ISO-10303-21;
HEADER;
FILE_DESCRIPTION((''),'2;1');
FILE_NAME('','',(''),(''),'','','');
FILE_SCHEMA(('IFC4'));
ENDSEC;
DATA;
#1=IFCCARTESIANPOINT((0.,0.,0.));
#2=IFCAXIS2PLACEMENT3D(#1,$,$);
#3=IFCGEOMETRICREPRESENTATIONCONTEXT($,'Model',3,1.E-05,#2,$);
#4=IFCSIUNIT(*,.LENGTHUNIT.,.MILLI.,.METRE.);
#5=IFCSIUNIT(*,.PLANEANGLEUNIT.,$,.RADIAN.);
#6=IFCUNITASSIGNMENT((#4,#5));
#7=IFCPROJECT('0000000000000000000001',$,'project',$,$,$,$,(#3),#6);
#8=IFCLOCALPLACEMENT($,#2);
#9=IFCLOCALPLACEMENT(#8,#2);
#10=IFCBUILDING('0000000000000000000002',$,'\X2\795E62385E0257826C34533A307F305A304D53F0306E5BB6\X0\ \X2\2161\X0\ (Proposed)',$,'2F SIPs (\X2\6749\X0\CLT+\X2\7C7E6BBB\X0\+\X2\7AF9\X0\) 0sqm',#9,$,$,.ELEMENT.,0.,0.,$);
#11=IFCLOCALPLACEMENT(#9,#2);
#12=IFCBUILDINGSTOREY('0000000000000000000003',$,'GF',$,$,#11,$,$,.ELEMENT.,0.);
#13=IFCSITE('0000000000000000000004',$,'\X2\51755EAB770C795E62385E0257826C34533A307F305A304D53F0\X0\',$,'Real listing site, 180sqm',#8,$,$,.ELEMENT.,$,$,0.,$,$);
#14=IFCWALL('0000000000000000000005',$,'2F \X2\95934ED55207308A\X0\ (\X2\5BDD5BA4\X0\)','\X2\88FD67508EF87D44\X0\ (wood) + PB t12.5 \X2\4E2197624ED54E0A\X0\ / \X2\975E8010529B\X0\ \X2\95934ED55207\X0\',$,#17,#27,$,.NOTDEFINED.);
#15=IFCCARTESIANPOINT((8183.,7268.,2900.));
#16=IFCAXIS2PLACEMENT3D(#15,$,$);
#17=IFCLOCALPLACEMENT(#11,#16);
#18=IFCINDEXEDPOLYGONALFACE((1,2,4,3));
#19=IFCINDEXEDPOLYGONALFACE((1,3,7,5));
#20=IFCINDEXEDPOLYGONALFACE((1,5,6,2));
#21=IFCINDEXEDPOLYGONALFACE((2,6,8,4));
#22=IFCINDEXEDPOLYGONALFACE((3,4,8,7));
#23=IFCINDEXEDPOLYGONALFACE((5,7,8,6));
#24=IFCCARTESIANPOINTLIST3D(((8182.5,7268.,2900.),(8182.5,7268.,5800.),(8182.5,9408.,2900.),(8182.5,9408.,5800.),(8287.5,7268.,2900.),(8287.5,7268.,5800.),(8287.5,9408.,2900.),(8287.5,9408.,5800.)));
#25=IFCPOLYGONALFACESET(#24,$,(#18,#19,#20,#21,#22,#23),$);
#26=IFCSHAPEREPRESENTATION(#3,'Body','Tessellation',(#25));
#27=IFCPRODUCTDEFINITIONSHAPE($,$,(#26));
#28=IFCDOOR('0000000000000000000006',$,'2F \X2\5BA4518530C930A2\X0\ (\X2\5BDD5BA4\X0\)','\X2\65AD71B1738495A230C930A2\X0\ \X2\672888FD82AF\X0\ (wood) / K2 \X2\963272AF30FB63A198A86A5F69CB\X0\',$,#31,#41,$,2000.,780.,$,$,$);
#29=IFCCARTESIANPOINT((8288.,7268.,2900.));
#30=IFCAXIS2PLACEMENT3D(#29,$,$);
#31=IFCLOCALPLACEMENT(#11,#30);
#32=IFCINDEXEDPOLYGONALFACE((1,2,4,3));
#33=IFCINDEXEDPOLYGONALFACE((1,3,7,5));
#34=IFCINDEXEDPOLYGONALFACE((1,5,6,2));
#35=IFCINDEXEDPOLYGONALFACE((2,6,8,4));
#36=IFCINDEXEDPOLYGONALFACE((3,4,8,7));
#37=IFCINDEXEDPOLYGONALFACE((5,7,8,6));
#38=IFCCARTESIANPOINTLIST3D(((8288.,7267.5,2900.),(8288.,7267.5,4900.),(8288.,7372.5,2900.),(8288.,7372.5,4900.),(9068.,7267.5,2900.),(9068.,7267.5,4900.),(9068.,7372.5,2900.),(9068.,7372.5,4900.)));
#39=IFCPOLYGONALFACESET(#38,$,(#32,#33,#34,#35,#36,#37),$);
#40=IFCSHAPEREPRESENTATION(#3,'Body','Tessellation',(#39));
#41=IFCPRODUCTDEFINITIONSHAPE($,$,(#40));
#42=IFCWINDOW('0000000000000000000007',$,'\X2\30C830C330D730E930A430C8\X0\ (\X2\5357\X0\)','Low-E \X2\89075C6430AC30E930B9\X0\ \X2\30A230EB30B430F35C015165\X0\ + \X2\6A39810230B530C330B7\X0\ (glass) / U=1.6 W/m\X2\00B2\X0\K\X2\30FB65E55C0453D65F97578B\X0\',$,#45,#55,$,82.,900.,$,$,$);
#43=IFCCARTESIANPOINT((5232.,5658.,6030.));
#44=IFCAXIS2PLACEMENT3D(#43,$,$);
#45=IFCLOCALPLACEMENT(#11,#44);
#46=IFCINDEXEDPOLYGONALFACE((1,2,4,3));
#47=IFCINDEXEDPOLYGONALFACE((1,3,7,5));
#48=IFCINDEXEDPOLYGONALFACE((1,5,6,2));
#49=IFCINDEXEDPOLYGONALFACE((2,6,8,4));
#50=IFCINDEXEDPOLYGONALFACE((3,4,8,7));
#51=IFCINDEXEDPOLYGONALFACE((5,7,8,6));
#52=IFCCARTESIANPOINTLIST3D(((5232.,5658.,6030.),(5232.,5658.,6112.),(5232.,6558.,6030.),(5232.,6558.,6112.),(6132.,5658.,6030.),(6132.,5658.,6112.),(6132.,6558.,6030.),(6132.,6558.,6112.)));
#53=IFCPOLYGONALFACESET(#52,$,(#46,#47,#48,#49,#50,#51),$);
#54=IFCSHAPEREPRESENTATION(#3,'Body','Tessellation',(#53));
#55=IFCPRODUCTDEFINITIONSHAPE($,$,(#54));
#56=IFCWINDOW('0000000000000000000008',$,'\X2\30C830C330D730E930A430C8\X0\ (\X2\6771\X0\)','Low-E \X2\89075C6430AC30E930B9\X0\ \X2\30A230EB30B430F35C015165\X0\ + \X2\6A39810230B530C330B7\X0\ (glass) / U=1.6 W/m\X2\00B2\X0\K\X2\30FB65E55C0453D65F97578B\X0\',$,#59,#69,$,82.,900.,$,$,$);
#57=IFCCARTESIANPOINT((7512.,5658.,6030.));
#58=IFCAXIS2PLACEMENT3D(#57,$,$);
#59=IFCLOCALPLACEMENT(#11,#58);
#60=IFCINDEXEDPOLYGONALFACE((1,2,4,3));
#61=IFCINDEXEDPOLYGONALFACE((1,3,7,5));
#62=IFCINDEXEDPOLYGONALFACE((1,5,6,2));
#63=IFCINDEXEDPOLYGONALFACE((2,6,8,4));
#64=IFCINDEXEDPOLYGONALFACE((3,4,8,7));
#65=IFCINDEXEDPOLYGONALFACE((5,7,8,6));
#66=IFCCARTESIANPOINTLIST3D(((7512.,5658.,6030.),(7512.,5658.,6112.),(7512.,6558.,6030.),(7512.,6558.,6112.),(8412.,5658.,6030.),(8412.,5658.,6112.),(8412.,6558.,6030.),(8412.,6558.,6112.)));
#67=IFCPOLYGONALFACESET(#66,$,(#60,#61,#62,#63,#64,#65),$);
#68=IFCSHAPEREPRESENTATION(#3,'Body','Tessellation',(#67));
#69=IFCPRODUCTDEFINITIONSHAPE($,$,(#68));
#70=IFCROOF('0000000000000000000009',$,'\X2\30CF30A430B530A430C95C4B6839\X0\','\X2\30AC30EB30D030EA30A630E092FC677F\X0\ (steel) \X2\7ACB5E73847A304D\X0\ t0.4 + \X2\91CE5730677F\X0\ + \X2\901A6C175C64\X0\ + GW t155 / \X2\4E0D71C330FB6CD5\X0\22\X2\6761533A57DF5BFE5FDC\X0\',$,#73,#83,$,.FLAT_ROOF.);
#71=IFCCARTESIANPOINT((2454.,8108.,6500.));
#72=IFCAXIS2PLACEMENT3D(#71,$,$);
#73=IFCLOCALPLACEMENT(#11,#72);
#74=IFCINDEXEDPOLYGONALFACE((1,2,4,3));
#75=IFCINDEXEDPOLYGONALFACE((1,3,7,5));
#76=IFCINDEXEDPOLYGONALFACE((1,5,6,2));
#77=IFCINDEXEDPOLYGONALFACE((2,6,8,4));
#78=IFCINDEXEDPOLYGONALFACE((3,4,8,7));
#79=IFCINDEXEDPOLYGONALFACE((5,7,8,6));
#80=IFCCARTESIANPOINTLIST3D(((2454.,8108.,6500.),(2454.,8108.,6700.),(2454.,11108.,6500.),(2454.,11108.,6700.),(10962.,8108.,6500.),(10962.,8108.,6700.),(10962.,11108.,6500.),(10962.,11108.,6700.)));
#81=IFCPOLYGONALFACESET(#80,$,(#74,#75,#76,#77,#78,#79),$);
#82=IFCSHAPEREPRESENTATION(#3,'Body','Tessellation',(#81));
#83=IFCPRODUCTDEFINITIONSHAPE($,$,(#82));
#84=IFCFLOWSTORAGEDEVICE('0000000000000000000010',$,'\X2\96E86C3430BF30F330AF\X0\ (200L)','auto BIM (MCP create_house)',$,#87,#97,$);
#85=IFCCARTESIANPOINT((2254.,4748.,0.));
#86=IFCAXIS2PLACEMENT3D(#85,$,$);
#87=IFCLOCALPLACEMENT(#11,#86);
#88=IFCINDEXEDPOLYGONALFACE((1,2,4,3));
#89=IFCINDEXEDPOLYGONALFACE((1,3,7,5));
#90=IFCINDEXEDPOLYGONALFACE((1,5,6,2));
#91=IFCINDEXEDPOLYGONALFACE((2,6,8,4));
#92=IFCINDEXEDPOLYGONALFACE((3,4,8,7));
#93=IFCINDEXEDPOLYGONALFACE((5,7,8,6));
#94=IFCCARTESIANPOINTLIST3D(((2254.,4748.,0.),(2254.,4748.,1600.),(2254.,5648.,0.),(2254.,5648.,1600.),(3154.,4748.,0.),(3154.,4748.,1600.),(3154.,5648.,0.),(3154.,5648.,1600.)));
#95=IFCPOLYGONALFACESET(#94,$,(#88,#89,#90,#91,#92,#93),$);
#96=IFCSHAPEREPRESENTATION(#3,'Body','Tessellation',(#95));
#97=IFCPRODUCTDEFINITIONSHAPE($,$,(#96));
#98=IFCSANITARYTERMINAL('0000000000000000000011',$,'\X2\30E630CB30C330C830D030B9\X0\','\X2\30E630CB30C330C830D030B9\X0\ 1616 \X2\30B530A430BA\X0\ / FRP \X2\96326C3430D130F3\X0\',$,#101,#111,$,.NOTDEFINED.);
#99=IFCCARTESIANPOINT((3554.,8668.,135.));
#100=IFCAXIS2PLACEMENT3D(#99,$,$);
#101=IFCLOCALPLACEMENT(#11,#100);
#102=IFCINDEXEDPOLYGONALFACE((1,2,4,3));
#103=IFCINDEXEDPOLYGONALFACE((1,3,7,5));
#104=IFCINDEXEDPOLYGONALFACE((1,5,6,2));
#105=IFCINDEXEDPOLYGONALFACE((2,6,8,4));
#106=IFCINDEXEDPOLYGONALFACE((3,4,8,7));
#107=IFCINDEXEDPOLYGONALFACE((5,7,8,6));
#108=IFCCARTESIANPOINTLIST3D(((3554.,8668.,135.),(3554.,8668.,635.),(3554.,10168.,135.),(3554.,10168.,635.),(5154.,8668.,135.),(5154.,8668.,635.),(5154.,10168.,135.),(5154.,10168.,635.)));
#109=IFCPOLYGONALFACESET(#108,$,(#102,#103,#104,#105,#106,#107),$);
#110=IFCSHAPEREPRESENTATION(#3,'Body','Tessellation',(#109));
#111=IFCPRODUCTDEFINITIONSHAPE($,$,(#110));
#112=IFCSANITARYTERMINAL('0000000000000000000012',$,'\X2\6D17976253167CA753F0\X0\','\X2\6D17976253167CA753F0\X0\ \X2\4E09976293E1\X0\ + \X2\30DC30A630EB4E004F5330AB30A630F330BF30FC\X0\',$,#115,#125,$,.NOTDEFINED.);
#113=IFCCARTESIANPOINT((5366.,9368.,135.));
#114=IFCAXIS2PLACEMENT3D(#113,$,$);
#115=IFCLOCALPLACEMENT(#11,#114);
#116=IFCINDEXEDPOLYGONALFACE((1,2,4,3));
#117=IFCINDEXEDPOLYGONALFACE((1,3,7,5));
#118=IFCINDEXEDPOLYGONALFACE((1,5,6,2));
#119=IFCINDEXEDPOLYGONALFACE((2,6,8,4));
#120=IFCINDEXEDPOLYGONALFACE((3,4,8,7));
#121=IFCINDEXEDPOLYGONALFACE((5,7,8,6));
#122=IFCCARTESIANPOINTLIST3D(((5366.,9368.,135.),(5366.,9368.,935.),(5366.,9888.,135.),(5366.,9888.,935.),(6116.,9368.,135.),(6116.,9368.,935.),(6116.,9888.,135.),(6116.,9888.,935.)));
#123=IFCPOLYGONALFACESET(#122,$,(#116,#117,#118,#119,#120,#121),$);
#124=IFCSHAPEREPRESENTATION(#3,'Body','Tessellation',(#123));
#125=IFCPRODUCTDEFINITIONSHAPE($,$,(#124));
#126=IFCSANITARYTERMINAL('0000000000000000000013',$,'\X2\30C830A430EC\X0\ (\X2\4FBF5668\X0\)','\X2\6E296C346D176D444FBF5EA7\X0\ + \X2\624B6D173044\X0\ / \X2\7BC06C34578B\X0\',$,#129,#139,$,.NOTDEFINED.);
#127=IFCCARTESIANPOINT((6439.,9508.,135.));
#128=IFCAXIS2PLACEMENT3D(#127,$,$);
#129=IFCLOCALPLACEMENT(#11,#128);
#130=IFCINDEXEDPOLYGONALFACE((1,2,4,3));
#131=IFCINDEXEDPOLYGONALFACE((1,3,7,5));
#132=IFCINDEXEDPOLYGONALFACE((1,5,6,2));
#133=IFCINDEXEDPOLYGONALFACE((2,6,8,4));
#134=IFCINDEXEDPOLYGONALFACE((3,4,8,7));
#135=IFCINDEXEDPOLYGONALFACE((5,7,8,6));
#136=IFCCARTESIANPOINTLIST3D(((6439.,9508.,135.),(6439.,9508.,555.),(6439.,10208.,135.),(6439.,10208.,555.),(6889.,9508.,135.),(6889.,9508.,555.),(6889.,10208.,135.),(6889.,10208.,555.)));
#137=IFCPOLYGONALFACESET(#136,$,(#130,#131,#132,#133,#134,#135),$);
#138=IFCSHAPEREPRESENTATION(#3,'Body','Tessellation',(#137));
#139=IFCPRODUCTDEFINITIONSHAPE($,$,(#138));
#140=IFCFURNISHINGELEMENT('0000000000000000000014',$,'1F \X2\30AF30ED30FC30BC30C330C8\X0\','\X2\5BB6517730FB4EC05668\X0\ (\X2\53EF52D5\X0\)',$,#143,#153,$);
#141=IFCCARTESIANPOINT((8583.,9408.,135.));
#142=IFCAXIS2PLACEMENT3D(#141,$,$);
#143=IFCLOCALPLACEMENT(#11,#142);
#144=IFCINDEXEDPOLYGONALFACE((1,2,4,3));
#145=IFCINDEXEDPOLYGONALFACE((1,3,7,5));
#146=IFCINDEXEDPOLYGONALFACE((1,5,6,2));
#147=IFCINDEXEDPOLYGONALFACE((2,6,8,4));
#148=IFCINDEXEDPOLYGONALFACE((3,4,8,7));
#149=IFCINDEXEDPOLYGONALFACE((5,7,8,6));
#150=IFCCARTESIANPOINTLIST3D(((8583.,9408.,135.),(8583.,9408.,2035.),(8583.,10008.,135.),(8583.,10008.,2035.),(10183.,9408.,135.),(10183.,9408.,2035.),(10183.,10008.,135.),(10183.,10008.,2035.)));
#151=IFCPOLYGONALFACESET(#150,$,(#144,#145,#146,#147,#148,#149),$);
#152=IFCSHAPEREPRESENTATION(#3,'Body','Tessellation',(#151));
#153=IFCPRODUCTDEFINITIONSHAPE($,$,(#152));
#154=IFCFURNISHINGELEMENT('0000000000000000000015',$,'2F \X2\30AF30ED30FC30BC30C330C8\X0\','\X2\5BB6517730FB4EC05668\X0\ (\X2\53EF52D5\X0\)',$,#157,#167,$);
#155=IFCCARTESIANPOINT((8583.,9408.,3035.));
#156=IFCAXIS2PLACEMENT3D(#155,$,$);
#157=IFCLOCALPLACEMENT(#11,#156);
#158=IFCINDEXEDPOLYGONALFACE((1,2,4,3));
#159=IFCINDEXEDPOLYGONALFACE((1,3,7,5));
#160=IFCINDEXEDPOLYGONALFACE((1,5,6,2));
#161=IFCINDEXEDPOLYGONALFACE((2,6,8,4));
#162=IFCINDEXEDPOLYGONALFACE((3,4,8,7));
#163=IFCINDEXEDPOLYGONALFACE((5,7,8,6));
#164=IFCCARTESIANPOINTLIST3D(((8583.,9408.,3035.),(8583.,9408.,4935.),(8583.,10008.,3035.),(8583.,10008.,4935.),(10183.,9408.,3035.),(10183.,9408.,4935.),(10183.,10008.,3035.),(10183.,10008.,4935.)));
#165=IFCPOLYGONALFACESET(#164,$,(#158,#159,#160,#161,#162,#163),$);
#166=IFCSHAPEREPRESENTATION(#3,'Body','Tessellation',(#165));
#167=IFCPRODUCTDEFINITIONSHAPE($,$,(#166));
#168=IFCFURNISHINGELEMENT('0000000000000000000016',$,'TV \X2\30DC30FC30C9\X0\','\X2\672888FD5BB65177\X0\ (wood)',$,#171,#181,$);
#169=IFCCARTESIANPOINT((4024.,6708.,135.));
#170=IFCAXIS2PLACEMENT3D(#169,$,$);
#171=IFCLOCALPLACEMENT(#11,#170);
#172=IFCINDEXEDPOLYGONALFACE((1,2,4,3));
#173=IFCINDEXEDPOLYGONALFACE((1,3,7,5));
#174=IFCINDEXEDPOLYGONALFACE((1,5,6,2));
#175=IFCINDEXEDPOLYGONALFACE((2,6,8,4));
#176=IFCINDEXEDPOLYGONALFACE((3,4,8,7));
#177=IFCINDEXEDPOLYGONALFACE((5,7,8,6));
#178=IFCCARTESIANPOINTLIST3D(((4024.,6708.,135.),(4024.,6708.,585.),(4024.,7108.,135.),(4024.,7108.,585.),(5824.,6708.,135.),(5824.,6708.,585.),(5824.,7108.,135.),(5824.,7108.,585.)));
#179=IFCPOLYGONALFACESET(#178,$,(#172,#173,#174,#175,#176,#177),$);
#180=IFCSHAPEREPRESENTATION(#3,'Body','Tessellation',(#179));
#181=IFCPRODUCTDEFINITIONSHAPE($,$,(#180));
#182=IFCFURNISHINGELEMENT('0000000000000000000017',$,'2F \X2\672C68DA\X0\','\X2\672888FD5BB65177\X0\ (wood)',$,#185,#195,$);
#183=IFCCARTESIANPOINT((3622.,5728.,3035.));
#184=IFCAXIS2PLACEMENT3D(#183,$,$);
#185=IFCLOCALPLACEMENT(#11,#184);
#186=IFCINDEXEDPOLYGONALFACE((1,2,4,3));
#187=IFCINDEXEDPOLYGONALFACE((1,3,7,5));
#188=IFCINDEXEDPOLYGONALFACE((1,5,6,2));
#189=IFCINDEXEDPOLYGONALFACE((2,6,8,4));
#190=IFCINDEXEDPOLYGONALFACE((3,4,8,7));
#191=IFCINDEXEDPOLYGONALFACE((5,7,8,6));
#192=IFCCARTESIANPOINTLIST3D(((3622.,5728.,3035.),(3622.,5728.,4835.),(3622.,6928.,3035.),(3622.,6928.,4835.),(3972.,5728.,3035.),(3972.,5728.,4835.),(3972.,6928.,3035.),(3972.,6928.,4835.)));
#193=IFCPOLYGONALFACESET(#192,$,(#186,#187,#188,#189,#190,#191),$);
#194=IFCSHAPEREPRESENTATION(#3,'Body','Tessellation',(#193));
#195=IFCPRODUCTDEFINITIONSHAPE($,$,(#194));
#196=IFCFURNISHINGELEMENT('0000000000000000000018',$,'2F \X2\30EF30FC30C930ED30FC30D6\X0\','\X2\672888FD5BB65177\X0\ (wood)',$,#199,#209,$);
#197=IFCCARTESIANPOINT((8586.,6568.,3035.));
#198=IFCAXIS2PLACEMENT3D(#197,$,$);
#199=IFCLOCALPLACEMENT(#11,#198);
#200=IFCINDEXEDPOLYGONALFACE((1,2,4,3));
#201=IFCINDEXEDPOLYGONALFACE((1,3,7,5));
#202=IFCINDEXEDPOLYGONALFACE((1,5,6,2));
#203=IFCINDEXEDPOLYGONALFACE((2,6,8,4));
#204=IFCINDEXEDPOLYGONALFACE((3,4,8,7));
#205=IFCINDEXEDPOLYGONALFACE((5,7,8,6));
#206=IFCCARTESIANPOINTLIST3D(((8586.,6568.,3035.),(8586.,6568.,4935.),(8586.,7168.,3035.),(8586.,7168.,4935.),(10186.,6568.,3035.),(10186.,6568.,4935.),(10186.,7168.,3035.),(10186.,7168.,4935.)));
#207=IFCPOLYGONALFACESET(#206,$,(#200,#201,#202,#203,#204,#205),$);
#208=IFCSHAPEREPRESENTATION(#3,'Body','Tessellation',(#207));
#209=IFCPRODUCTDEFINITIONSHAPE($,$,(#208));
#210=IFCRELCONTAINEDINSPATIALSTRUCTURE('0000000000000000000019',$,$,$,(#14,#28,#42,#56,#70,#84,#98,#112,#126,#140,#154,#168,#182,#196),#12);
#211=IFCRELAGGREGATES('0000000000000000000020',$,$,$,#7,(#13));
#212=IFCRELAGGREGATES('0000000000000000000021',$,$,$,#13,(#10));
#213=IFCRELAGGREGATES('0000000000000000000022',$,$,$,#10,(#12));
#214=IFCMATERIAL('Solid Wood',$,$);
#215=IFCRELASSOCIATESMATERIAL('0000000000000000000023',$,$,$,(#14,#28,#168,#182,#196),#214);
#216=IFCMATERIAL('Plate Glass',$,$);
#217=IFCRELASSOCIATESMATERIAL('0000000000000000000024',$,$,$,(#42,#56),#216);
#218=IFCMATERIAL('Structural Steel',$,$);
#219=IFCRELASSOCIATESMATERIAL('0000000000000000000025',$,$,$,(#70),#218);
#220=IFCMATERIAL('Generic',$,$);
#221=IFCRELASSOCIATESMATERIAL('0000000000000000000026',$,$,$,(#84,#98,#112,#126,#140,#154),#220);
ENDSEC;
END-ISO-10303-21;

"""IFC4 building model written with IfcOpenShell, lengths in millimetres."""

from ifc_helpers import new_model, si_unit, frame, frame_2d, origin, place, context, project, spatial, rectangle, extrude, material, element, save


model = new_model("IFC4")

# Units and contexts
model_context = context("Model", 3, precision=1e-05, world=origin())
ifc_project = project(units=[si_unit("LENGTHUNIT", "METRE", prefix="MILLI"), si_unit("PLANEANGLEUNIT", "RADIAN")], contexts=[model_context])

# Site, building, storey
site_placement = place(None, origin())
site = spatial("IfcSite", under=ifc_project, at=site_placement, Name="兵庫県神戸市垂水区みずき台", ObjectType="Real listing site, 180sqm", CompositionType="ELEMENT", RefElevation=0.0)
building_placement = place(site_placement, origin())
building = spatial("IfcBuilding", under=site, at=building_placement, Name="神戸市垂水区みずき台の家 Ⅱ (Proposed)", ObjectType="2F SIPs (杉CLT+籾殻+竹) 0sqm", CompositionType="ELEMENT", ElevationOfRefHeight=0.0, ElevationOfTerrain=0.0)
storey_placement = place(building_placement, origin())
storey = spatial("IfcBuildingStorey", under=building, at=storey_placement, Name="GF", CompositionType="ELEMENT", Elevation=0.0)

# Shared definitions
ifc_material_1 = material(Name="Solid Wood")
ifc_material_2 = material(Name="Plate Glass")

# Wall
wall_1_placement = place(storey_placement, frame((8183.0, 7268.0, 2900.0)))
element("IfcWall", 1, at=wall_1_placement, inside=storey, material=ifc_material_1, Name="2F 間仕切り (寝室)", Description="製材軸組 (wood) + PB t12.5 両面仕上 / 非耐力 間仕切", PredefinedType="NOTDEFINED", context=model_context, shape_type="SweptSolid", body=[
    extrude(rectangle(XDim=105.0, YDim=2140.0, at=frame_2d((52.0, 1070.0))), frame((8183.0, 7268.0, 2900.0)), (0.0, 0.0, 1.0), 2900.0),
])

# Door
door_1_placement = place(storey_placement, frame((8288.0, 7268.0, 2900.0)))
element("IfcDoor", 2, at=door_1_placement, inside=storey, material=ifc_material_1, Name="2F 室内ドア (寝室)", Description="断熱玄関ドア 木製芯 (wood) / K2 防犯・採風機構", OverallHeight=2000.0, OverallWidth=780.0, context=model_context, shape_type="SweptSolid", body=[
    extrude(rectangle(XDim=780.0, YDim=105.0, at=frame_2d((390.0, 52.0))), frame((8288.0, 7268.0, 2900.0)), (0.0, 0.0, 1.0), 2000.0),
])

# Windows
window_1_placement = place(storey_placement, frame((5232.0, 5658.0, 6030.0)))
element("IfcWindow", 3, at=window_1_placement, inside=storey, material=ifc_material_2, Name="トップライト (南)", Description="Low-E 複層ガラス アルゴン封入 + 樹脂サッシ (glass) / U=1.6 W/m²K・日射取得型", OverallHeight=82.0, OverallWidth=900.0, context=model_context, shape_type="SweptSolid", body=[
    extrude(rectangle(XDim=900.0, YDim=900.0, at=frame_2d((450.0, 450.0))), frame((5232.0, 5658.0, 6030.0)), (0.0, 0.0, 1.0), 82.0),
])
window_2_placement = place(storey_placement, frame((7512.0, 5658.0, 6030.0)))
element("IfcWindow", 4, at=window_2_placement, inside=storey, material=ifc_material_2, Name="トップライト (東)", Description="Low-E 複層ガラス アルゴン封入 + 樹脂サッシ (glass) / U=1.6 W/m²K・日射取得型", OverallHeight=82.0, OverallWidth=900.0, context=model_context, shape_type="SweptSolid", body=[
    extrude(rectangle(XDim=900.0, YDim=900.0, at=frame_2d((450.0, 450.0))), frame((7512.0, 5658.0, 6030.0)), (0.0, 0.0, 1.0), 82.0),
])

# Roof
ifc_material_3 = material(Name="Structural Steel")
roof_placement = place(storey_placement, frame((2454.0, 8108.0, 6500.0)))
element("IfcRoof", 5, at=roof_placement, inside=storey, material=ifc_material_3, Name="ハイサイド屋根", Description="ガルバリウム鋼板 (steel) 立平葺き t0.4 + 野地板 + 通気層 + GW t155 / 不燃・法22条区域対応", PredefinedType="FLAT_ROOF", context=model_context, shape_type="SweptSolid", body=[
    extrude(rectangle(XDim=8508.0, YDim=3000.0, at=frame_2d((4254.0, 1500.0))), frame((2454.0, 8108.0, 6500.0)), (0.0, 0.0, 1.0), 200.0),
])

# Flow storage device
ifc_material_4 = material(Name="Generic")
flow_storage_device_placement = place(storey_placement, frame((2254.0, 4748.0, 0.0)))
element("IfcFlowStorageDevice", 6, at=flow_storage_device_placement, inside=storey, material=ifc_material_4, Name="雨水タンク (200L)", Description="auto BIM (MCP create_house)", context=model_context, shape_type="SweptSolid", body=[
    extrude(rectangle(XDim=900.0, YDim=900.0, at=frame_2d((450.0, 450.0))), frame((2254.0, 4748.0, 0.0)), (0.0, 0.0, 1.0), 1600.0),
])

# Sanitary terminals
sanitary_terminal_1_placement = place(storey_placement, frame((3554.0, 8668.0, 135.0)))
element("IfcSanitaryTerminal", 7, at=sanitary_terminal_1_placement, inside=storey, material=ifc_material_4, Name="ユニットバス", Description="ユニットバス 1616 サイズ / FRP 防水パン", PredefinedType="NOTDEFINED", context=model_context, shape_type="SweptSolid", body=[
    extrude(rectangle(XDim=1600.0, YDim=1500.0, at=frame_2d((800.0, 750.0))), frame((3554.0, 8668.0, 135.0)), (0.0, 0.0, 1.0), 500.0),
])
sanitary_terminal_2_placement = place(storey_placement, frame((5366.0, 9368.0, 135.0)))
element("IfcSanitaryTerminal", 8, at=sanitary_terminal_2_placement, inside=storey, material=ifc_material_4, Name="洗面化粧台", Description="洗面化粧台 三面鏡 + ボウル一体カウンター", PredefinedType="NOTDEFINED", context=model_context, shape_type="SweptSolid", body=[
    extrude(rectangle(XDim=750.0, YDim=520.0, at=frame_2d((375.0, 260.0))), frame((5366.0, 9368.0, 135.0)), (0.0, 0.0, 1.0), 800.0),
])
sanitary_terminal_3_placement = place(storey_placement, frame((6439.0, 9508.0, 135.0)))
element("IfcSanitaryTerminal", 9, at=sanitary_terminal_3_placement, inside=storey, material=ifc_material_4, Name="トイレ (便器)", Description="温水洗浄便座 + 手洗い / 節水型", PredefinedType="NOTDEFINED", context=model_context, shape_type="SweptSolid", body=[
    extrude(rectangle(XDim=450.0, YDim=700.0, at=frame_2d((225.0, 350.0))), frame((6439.0, 9508.0, 135.0)), (0.0, 0.0, 1.0), 420.0),
])

# Furnishing elements
furnishing_1_placement = place(storey_placement, frame((8583.0, 9408.0, 135.0)))
element("IfcFurnishingElement", 10, at=furnishing_1_placement, inside=storey, material=ifc_material_4, Name="1F クローゼット", Description="家具・什器 (可動)", context=model_context, shape_type="SweptSolid", body=[
    extrude(rectangle(XDim=1600.0, YDim=600.0, at=frame_2d((800.0, 300.0))), frame((8583.0, 9408.0, 135.0)), (0.0, 0.0, 1.0), 1900.0),
])
furnishing_2_placement = place(storey_placement, frame((8583.0, 9408.0, 3035.0)))
element("IfcFurnishingElement", 11, at=furnishing_2_placement, inside=storey, material=ifc_material_4, Name="2F クローゼット", Description="家具・什器 (可動)", context=model_context, shape_type="SweptSolid", body=[
    extrude(rectangle(XDim=1600.0, YDim=600.0, at=frame_2d((800.0, 300.0))), frame((8583.0, 9408.0, 3035.0)), (0.0, 0.0, 1.0), 1900.0),
])
furnishing_3_placement = place(storey_placement, frame((4024.0, 6708.0, 135.0)))
element("IfcFurnishingElement", 12, at=furnishing_3_placement, inside=storey, material=ifc_material_1, Name="TV ボード", Description="木製家具 (wood)", context=model_context, shape_type="SweptSolid", body=[
    extrude(rectangle(XDim=1800.0, YDim=400.0, at=frame_2d((900.0, 200.0))), frame((4024.0, 6708.0, 135.0)), (0.0, 0.0, 1.0), 450.0),
])
furnishing_4_placement = place(storey_placement, frame((3622.0, 5728.0, 3035.0)))
element("IfcFurnishingElement", 13, at=furnishing_4_placement, inside=storey, material=ifc_material_1, Name="2F 本棚", Description="木製家具 (wood)", context=model_context, shape_type="SweptSolid", body=[
    extrude(rectangle(XDim=350.0, YDim=1200.0, at=frame_2d((175.0, 600.0))), frame((3622.0, 5728.0, 3035.0)), (0.0, 0.0, 1.0), 1800.0),
])
furnishing_5_placement = place(storey_placement, frame((8586.0, 6568.0, 3035.0)))
element("IfcFurnishingElement", 14, at=furnishing_5_placement, inside=storey, material=ifc_material_1, Name="2F ワードローブ", Description="木製家具 (wood)", context=model_context, shape_type="SweptSolid", body=[
    extrude(rectangle(XDim=1600.0, YDim=600.0, at=frame_2d((800.0, 300.0))), frame((8586.0, 6568.0, 3035.0)), (0.0, 0.0, 1.0), 1900.0),
])

save(model, "model.ifc")
